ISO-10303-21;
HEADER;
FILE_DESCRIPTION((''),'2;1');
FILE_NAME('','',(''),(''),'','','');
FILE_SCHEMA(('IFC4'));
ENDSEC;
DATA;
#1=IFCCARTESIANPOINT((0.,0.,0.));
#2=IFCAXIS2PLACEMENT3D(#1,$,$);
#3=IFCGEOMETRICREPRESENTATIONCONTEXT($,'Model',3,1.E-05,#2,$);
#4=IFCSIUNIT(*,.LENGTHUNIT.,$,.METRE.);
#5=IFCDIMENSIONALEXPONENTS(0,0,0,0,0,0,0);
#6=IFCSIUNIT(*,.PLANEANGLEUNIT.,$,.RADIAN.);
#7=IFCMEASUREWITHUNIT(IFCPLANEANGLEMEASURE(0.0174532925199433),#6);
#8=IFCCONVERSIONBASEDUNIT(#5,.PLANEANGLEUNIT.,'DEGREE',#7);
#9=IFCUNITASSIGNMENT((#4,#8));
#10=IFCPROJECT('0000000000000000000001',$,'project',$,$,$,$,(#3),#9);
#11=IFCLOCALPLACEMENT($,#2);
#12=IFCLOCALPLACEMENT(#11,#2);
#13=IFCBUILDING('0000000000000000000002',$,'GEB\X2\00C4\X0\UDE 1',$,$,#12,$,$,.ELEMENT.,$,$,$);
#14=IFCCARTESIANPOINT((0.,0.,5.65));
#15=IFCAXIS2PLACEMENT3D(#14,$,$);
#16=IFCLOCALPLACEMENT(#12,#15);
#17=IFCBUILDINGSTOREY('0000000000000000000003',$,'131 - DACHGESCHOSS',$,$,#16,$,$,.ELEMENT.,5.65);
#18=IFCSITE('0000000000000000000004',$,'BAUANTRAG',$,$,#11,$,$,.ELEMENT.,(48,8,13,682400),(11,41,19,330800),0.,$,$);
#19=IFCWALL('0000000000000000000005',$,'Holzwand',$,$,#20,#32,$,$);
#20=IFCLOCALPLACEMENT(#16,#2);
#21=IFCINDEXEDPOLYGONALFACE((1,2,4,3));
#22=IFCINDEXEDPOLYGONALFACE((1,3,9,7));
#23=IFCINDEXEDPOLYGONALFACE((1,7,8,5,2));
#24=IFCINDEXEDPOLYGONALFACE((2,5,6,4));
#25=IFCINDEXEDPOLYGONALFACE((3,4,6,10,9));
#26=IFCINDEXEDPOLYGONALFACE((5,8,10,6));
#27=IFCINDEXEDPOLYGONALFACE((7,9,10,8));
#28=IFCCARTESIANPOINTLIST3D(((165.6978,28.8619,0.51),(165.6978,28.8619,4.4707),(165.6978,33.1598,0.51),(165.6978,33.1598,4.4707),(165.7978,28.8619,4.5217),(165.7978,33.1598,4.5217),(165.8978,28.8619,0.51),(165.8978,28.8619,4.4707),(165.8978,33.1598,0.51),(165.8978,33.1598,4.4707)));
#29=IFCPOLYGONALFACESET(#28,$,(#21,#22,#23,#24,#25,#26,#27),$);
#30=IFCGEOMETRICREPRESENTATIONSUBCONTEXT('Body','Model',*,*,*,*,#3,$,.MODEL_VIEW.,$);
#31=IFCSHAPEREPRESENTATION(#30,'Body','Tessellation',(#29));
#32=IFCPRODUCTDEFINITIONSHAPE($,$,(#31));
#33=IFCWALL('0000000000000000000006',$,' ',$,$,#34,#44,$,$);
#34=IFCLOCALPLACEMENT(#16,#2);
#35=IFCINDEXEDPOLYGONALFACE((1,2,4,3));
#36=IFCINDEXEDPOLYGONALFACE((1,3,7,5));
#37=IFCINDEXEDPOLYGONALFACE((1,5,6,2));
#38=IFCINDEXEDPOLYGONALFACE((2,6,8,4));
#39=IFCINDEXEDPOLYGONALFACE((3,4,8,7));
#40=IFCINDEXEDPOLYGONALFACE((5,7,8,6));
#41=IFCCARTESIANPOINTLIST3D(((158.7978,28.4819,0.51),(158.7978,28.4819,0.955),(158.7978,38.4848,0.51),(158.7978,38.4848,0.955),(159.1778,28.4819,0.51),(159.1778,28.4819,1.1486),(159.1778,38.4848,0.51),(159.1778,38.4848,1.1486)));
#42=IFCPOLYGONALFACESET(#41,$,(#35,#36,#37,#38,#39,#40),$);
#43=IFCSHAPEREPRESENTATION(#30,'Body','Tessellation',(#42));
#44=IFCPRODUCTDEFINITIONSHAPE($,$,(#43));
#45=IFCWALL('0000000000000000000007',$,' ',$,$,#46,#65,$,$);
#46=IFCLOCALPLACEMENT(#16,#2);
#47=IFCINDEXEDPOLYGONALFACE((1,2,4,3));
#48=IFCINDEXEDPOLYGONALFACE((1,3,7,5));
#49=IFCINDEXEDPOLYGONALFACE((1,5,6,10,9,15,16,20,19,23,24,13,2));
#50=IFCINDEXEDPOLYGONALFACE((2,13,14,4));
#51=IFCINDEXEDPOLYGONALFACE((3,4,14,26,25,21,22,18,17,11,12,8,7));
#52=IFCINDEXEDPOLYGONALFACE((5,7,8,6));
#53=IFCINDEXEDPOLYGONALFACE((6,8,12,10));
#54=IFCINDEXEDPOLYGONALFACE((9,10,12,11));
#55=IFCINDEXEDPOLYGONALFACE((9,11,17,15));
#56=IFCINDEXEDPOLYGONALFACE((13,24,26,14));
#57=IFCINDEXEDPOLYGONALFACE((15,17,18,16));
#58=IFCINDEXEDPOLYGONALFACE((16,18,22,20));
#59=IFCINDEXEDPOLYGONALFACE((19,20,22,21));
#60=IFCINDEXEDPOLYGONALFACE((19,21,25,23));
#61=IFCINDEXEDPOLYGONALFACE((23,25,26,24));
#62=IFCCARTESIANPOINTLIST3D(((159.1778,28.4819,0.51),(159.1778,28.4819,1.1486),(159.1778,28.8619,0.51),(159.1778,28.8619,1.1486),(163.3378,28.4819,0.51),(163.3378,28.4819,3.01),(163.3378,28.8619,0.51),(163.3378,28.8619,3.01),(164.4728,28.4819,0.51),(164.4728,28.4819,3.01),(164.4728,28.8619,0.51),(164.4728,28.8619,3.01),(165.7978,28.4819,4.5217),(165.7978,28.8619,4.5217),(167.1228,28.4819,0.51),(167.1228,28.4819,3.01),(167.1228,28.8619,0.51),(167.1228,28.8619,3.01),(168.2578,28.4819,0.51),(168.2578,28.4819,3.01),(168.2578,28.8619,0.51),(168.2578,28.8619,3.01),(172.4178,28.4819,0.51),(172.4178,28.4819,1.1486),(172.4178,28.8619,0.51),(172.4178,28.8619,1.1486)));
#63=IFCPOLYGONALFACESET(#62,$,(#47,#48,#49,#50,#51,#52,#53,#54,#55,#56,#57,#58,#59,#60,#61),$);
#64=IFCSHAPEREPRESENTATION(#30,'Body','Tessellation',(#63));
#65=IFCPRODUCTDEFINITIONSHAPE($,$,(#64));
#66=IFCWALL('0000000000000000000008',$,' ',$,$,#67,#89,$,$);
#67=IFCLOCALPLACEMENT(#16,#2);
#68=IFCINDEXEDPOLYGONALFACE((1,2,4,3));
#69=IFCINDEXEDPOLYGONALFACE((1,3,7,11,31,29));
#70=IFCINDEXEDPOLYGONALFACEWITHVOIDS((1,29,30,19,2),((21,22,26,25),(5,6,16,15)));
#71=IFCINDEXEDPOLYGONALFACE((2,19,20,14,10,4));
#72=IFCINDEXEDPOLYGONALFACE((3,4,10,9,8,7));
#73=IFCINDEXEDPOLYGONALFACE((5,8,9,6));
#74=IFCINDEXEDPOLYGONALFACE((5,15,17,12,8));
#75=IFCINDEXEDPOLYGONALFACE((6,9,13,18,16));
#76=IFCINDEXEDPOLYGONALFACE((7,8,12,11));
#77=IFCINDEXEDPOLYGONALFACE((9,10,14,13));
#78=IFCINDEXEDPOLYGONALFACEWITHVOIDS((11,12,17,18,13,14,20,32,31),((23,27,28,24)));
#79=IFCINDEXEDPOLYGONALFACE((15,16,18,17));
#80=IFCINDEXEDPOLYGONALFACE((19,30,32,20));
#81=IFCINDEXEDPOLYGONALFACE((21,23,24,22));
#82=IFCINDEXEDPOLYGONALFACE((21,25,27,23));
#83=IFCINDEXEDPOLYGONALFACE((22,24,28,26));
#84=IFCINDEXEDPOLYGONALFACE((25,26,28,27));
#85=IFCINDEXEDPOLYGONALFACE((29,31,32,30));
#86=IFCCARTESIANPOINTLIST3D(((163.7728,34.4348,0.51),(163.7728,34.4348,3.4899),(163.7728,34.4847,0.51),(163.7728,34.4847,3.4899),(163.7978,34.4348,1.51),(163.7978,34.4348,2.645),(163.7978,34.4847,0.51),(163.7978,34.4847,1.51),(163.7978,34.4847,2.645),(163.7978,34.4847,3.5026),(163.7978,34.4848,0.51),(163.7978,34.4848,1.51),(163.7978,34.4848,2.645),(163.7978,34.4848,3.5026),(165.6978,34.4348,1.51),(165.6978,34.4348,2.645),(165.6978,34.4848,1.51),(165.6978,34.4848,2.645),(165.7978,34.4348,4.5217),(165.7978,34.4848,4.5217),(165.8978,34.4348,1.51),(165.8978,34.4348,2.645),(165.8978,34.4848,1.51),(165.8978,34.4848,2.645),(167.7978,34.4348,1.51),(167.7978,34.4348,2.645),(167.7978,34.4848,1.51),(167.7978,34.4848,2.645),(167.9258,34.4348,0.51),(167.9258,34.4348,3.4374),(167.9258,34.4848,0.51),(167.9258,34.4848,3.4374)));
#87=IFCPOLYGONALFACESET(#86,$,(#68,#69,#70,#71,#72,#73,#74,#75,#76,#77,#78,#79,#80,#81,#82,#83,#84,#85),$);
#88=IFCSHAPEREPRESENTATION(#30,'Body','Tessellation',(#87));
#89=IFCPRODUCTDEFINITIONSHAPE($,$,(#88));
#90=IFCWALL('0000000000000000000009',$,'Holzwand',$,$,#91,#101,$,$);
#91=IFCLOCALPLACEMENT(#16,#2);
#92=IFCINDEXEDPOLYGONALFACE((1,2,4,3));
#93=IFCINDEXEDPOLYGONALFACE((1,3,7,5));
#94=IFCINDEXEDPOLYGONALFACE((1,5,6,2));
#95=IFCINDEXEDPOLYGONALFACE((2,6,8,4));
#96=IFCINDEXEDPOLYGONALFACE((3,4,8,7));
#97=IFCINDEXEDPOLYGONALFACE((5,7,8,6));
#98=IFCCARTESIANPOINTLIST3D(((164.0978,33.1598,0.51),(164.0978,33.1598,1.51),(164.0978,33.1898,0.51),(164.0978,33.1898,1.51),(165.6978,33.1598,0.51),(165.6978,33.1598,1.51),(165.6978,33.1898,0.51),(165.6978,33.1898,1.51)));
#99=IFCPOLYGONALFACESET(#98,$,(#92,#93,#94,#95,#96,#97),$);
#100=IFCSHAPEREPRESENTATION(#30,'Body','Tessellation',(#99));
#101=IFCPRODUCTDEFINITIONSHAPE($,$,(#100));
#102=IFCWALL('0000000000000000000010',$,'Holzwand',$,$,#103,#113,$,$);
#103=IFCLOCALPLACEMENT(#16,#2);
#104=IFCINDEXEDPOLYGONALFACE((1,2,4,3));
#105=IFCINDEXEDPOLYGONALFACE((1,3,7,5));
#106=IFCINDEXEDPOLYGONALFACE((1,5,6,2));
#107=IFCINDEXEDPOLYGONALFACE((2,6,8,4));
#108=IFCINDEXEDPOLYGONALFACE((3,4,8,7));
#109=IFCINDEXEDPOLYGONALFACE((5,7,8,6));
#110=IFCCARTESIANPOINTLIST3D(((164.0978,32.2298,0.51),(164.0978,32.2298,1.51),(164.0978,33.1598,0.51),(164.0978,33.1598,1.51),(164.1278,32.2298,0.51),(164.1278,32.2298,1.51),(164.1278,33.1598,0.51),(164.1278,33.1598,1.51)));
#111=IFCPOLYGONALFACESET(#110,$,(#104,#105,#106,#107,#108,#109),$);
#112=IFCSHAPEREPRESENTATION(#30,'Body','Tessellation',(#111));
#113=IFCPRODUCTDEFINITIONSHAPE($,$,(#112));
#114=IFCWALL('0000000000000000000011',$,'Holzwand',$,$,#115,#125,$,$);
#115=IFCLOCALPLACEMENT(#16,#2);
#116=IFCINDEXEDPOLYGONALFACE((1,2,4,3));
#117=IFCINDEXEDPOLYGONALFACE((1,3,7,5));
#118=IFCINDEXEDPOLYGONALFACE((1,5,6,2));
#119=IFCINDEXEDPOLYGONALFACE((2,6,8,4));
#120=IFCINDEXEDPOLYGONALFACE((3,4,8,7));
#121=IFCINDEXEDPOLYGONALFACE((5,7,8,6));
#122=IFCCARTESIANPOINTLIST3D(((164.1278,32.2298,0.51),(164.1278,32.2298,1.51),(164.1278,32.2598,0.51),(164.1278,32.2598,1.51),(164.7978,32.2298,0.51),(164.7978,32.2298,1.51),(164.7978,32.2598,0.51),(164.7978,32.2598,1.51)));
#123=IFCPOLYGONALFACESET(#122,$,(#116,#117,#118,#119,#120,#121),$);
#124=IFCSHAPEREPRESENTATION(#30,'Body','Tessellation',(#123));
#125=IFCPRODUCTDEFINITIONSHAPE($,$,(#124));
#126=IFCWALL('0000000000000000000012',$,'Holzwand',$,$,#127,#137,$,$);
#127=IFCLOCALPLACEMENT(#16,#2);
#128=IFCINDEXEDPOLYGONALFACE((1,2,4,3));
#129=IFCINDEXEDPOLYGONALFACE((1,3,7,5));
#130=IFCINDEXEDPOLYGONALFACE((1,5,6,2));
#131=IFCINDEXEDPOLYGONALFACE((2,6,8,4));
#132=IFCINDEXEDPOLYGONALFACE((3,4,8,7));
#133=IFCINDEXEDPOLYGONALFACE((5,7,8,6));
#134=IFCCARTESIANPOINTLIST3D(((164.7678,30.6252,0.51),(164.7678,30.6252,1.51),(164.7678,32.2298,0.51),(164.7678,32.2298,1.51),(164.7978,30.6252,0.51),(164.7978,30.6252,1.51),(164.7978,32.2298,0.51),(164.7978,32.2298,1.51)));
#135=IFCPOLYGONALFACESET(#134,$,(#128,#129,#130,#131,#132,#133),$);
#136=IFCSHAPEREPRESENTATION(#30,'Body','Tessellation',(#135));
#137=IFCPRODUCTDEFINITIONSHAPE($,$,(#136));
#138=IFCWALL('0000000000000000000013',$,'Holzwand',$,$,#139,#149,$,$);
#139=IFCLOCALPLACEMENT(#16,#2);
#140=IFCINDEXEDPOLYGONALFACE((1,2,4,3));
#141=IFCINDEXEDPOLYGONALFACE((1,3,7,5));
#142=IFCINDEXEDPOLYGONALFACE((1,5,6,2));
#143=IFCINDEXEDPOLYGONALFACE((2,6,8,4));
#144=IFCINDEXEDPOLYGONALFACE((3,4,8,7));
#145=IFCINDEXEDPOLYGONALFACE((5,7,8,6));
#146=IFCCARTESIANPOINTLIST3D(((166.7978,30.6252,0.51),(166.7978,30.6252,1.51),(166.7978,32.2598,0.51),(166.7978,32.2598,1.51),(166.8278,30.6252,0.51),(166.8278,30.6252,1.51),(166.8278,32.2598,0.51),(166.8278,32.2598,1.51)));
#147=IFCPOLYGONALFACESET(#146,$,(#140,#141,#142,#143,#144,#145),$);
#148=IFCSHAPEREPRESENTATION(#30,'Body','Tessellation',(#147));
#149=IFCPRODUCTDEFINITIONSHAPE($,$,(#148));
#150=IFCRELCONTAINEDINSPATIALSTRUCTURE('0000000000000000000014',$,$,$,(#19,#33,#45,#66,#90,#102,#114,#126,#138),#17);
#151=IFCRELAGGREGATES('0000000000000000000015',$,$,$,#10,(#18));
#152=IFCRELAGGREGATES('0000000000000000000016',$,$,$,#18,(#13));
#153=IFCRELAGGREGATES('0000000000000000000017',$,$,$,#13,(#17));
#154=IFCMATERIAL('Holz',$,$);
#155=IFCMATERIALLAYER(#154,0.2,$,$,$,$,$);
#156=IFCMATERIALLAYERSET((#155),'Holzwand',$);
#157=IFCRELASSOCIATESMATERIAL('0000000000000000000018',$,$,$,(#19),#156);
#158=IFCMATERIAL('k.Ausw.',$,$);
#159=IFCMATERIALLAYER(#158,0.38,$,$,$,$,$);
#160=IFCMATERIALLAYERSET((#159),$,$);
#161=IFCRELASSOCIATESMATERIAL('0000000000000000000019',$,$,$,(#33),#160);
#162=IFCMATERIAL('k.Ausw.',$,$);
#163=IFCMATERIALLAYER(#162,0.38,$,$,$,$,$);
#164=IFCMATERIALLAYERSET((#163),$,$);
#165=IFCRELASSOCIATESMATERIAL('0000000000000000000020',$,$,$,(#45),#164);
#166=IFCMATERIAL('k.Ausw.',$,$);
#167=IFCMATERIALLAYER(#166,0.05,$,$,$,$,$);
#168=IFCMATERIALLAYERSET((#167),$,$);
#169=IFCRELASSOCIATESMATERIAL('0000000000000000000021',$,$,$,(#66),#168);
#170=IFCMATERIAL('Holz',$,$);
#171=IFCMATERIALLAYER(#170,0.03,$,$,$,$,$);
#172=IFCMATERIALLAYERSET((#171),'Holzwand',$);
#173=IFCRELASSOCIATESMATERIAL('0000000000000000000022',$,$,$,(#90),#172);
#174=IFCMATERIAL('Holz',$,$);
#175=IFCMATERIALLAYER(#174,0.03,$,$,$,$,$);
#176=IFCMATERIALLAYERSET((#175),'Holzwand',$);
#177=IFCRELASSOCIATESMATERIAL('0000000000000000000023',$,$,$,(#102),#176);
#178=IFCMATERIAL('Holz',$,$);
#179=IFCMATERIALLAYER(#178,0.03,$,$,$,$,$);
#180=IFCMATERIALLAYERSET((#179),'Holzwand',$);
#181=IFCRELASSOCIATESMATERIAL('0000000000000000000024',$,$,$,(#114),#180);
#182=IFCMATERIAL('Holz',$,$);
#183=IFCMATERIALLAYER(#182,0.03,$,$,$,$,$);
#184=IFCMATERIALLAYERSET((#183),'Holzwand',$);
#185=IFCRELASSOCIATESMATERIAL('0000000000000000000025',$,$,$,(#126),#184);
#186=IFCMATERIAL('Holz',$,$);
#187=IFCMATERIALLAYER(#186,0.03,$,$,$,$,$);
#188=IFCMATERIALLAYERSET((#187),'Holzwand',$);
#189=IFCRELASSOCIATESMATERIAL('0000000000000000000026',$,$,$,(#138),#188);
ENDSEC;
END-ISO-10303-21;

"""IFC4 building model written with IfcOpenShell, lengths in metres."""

from ifc_helpers import new_model, entity, si_unit, converted_unit, frame, frame_2d, origin, origin_with_axes, place, context, subcontext, project, spatial, polyline, rectangle, outline, extrude, clip, halfspace, bounded_halfspace, material, layer, layer_set, layer_usage, element, save


model = new_model("IFC4")

# Units and contexts
model_context = context("Model", 3, precision=1e-05, world=origin())
body_context = subcontext(model_context, "Body", "Model", "MODEL_VIEW")
ifc_project = project(units=[si_unit("LENGTHUNIT", "METRE"), converted_unit("PLANEANGLEUNIT", "DEGREE", entity("IfcPlaneAngleMeasure", 0.0174532925199433), si_unit("PLANEANGLEUNIT", "RADIAN"), dimensions=[0, 0, 0, 0, 0, 0, 0])], contexts=[model_context])

# Site, building, storey
site_placement = place(None, origin())
site = spatial("IfcSite", under=ifc_project, at=site_placement, Name="BAUANTRAG", CompositionType="ELEMENT", RefLatitude=(48, 8, 13, 682400), RefLongitude=(11, 41, 19, 330800), RefElevation=0.0)
building_placement = place(site_placement, origin())
building = spatial("IfcBuilding", under=site, at=building_placement, Name="GEBÄUDE 1", CompositionType="ELEMENT")
storey_placement = place(building_placement, frame((0.0, 0.0, 5.65)))
storey = spatial("IfcBuildingStorey", under=building, at=storey_placement, Name="131 - DACHGESCHOSS", CompositionType="ELEMENT", Elevation=5.65)

# Walls
ifc_material_1 = material(Name="Holz")
ifc_layer_1 = layer(ifc_material_1, 0.2)
ifc_layer_set_1 = layer_set([ifc_layer_1], Name="Holzwand")
ifc_layer_usage_1 = layer_usage(ifc_layer_set_1, "AXIS2", "POSITIVE", 0.0)
wall_1_placement = place(storey_placement, frame((165.6978, 33.1598, 0.51), z_axis=(0.0, 0.0, 1.0), x_axis=(0.0, -1.0, 0.0)))
element("IfcWall", 1, at=wall_1_placement, inside=storey, material=ifc_layer_usage_1, Name="Holzwand", context=body_context, shape_type="Clipping", body=[
    clip(clip(extrude(rectangle(XDim=4.2979, YDim=0.2, at=frame_2d((2.1489, 0.1), x_axis=(1.0, 0.0))), origin_with_axes(), (0.0, 0.0, 1.0), 4.0117), bounded_halfspace(frame((2.1489, 0.05, 3.9862), z_axis=(0.0, 0.45399, -0.891007), x_axis=(0.0, 0.891007, 0.45399)), True, origin_with_axes(), polyline([(4.2979, 0.0), (4.2979, 0.1), (0.0, 0.1), (0.0, 0.0), (4.2979, 0.0)]))), bounded_halfspace(frame((2.1489, 0.15, 3.9862), z_axis=(0.0, -0.45399, -0.891007), x_axis=(0.0, -0.891007, 0.45399)), True, origin_with_axes(), polyline([(0.0, 0.2), (0.0, 0.1), (4.2979, 0.1), (4.2979, 0.2), (0.0, 0.2)]))),
])
ifc_material_2 = material(Name="k.Ausw.")
ifc_layer_2 = layer(ifc_material_2, 0.38)
ifc_layer_set_2 = layer_set([ifc_layer_2])
ifc_layer_usage_2 = layer_usage(ifc_layer_set_2, "AXIS2", "POSITIVE", 0.0)
wall_2_placement = place(storey_placement, frame((158.7978, 38.4848, 0.51), z_axis=(0.0, 0.0, 1.0), x_axis=(0.0, -1.0, 0.0)))
element("IfcWall", 2, at=wall_2_placement, inside=storey, material=ifc_layer_usage_2, Name=" ", context=body_context, shape_type="Clipping", body=[
    clip(extrude(rectangle(XDim=10.0029, YDim=0.38, at=frame_2d((5.0014, 0.19), x_axis=(1.0, 0.0))), origin_with_axes(), (0.0, 0.0, 1.0), 0.6386), halfspace(frame((5.0014, 0.19, 0.5418), z_axis=(0.0, 0.45399, -0.891007), x_axis=(0.0, -0.891007, -0.45399)), True)),
])

# Walls, openings
ifc_material_3 = material(Name="k.Ausw.")
ifc_layer_3 = layer(ifc_material_3, 0.38)
ifc_layer_set_3 = layer_set([ifc_layer_3])
ifc_layer_usage_3 = layer_usage(ifc_layer_set_3, "AXIS2", "POSITIVE", 0.0)
wall_3_placement = place(storey_placement, frame((159.1778, 28.4819, 0.51), z_axis=(0.0, 0.0, 1.0), x_axis=(1.0, 0.0, 0.0)))
wall_3 = element("IfcWall", 3, at=wall_3_placement, inside=storey, material=ifc_layer_usage_3, Name=" ", context=body_context, shape_type="Clipping", body=[
    clip(clip(extrude(rectangle(XDim=13.24, YDim=0.38, at=frame_2d((6.62, 0.19), x_axis=(1.0, 0.0))), origin_with_axes(), (0.0, 0.0, 1.0), 4.0117), bounded_halfspace(frame((3.31, 0.19, 2.3251), z_axis=(0.45399, 0.0, -0.891007), x_axis=(0.0, -1.0, 0.0)), True, origin_with_axes(), polyline([(0.0, 0.38), (0.0, 0.0), (6.62, 0.0), (6.62, 0.38), (0.0, 0.38)]))), bounded_halfspace(frame((9.93, 0.19, 2.3251), z_axis=(-0.45399, 0.0, -0.891007), x_axis=(0.891007, 0.0, -0.45399)), True, origin_with_axes(), polyline([(6.62, 0.0), (13.24, 0.0), (13.24, 0.38), (6.62, 0.38), (6.62, 0.0)]))),
])
opening_1_placement = place(wall_3_placement, frame((5.295, 0.38, 0.0), z_axis=(0.0, -1.0, 0.0), x_axis=(0.0, 0.0, 1.0)))
element("IfcOpeningElement", 4, at=opening_1_placement, cuts=wall_3, ObjectType="Opening", context=body_context, shape_type="SweptSolid", body=[
    extrude(outline(polyline([(0.0, 1.135), (2.5, 1.135), (2.5, 0.0), (0.0, 0.0), (0.0, 1.135)])), origin_with_axes(), (0.0, 0.0, 1.0), 0.38),
])
opening_2_placement = place(wall_3_placement, frame((9.08, 0.38, 0.0), z_axis=(0.0, -1.0, 0.0), x_axis=(0.0, 0.0, 1.0)))
element("IfcOpeningElement", 5, at=opening_2_placement, cuts=wall_3, ObjectType="Opening", context=body_context, shape_type="SweptSolid", body=[
    extrude(outline(polyline([(0.0, 1.135), (2.5, 1.135), (2.5, 0.0), (0.0, 0.0), (0.0, 1.135)])), origin_with_axes(), (0.0, 0.0, 1.0), 0.38),
])
ifc_material_4 = material(Name="k.Ausw.")
ifc_layer_4 = layer(ifc_material_4, 0.05)
ifc_layer_set_4 = layer_set([ifc_layer_4])
ifc_layer_usage_4 = layer_usage(ifc_layer_set_4, "AXIS2", "POSITIVE", 0.0)
wall_4_placement = place(storey_placement, frame((163.7728, 34.4348, 0.51), z_axis=(0.0, 0.0, 1.0), x_axis=(1.0, 0.0, 0.0)))
wall_4 = element("IfcWall", 6, at=wall_4_placement, inside=storey, material=ifc_layer_usage_4, Name=" ", context=body_context, shape_type="Clipping", body=[
    clip(clip(extrude(outline(polyline([(0.0, 0.0), (4.153, 0.0), (4.153, 0.05), (0.025, 0.05), (0.025, 0.0499), (0.0, 0.0499), (0.0, 0.0)])), origin_with_axes(), (0.0, 0.0, 1.0), 4.0117), bounded_halfspace(frame((0.6833, 0.0333, 3.3281), z_axis=(0.45399, 0.0, -0.891007), x_axis=(0.891007, 0.0, 0.45399)), True, origin_with_axes(), polyline([(0.0, 0.0), (2.025, 0.0), (2.025, 0.05), (0.025, 0.05), (0.025, 0.0499), (0.0, 0.0499), (0.0, 0.0)]))), bounded_halfspace(frame((3.089, 0.025, 3.4695), z_axis=(-0.45399, 0.0, -0.891007), x_axis=(-0.891007, 0.0, 0.45399)), True, origin_with_axes(), polyline([(4.153, 0.05), (2.025, 0.05), (2.025, 0.0), (4.153, 0.0), (4.153, 0.05)]))),
])
opening_3_placement = place(wall_4_placement, frame((0.025, 0.0, 1.0), z_axis=(0.0, 1.0, 0.0), x_axis=(0.0, 0.0, 1.0)))
element("IfcOpeningElement", 7, at=opening_3_placement, cuts=wall_4, ObjectType="Opening", context=body_context, shape_type="SweptSolid", body=[
    extrude(outline(polyline([(0.0, 1.9), (1.135, 1.9), (1.135, 0.0), (0.0, 0.0), (0.0, 1.9)])), origin_with_axes(), (0.0, 0.0, 1.0), 0.05),
])
opening_4_placement = place(wall_4_placement, frame((2.125, 0.0, 1.0), z_axis=(0.0, 1.0, 0.0), x_axis=(0.0, 0.0, 1.0)))
element("IfcOpeningElement", 8, at=opening_4_placement, cuts=wall_4, ObjectType="Opening", context=body_context, shape_type="SweptSolid", body=[
    extrude(outline(polyline([(0.0, 1.9), (1.135, 1.9), (1.135, 0.0), (0.0, 0.0), (0.0, 1.9)])), origin_with_axes(), (0.0, 0.0, 1.0), 0.05),
])

# Walls
ifc_material_5 = material(Name="Holz")
ifc_layer_5 = layer(ifc_material_5, 0.03)
ifc_layer_set_5 = layer_set([ifc_layer_5], Name="Holzwand")
ifc_layer_usage_5 = layer_usage(ifc_layer_set_5, "AXIS2", "POSITIVE", 0.0)
wall_5_placement = place(storey_placement, frame((164.0978, 33.1598, 0.51)))
element("IfcWall", 9, at=wall_5_placement, inside=storey, material=ifc_layer_usage_5, Name="Holzwand", context=body_context, shape_type="SweptSolid", body=[
    extrude(rectangle(XDim=1.6, YDim=0.03, at=frame_2d((0.8, 0.015), x_axis=(1.0, 0.0))), origin_with_axes(), (0.0, 0.0, 1.0), 1.0),
])
ifc_material_6 = material(Name="Holz")
ifc_layer_6 = layer(ifc_material_6, 0.03)
ifc_layer_set_6 = layer_set([ifc_layer_6], Name="Holzwand")
ifc_layer_usage_6 = layer_usage(ifc_layer_set_6, "AXIS2", "POSITIVE", 0.0)
wall_6_placement = place(storey_placement, frame((164.1278, 32.2298, 0.51), z_axis=(0.0, 0.0, 1.0), x_axis=(0.0, 1.0, 0.0)))
element("IfcWall", 10, at=wall_6_placement, inside=storey, material=ifc_layer_usage_6, Name="Holzwand", context=body_context, shape_type="SweptSolid", body=[
    extrude(rectangle(XDim=0.93, YDim=0.03, at=frame_2d((0.465, 0.015), x_axis=(1.0, 0.0))), origin_with_axes(), (0.0, 0.0, 1.0), 1.0),
])
ifc_material_7 = material(Name="Holz")
ifc_layer_7 = layer(ifc_material_7, 0.03)
ifc_layer_set_7 = layer_set([ifc_layer_7], Name="Holzwand")
ifc_layer_usage_7 = layer_usage(ifc_layer_set_7, "AXIS2", "POSITIVE", 0.0)
wall_7_placement = place(storey_placement, frame((164.7978, 32.2598, 0.51), z_axis=(0.0, 0.0, 1.0), x_axis=(-1.0, 0.0, 0.0)))
element("IfcWall", 11, at=wall_7_placement, inside=storey, material=ifc_layer_usage_7, Name="Holzwand", context=body_context, shape_type="SweptSolid", body=[
    extrude(rectangle(XDim=0.67, YDim=0.03, at=frame_2d((0.335, 0.015), x_axis=(1.0, 0.0))), origin_with_axes(), (0.0, 0.0, 1.0), 1.0),
])
ifc_material_8 = material(Name="Holz")
ifc_layer_8 = layer(ifc_material_8, 0.03)
ifc_layer_set_8 = layer_set([ifc_layer_8], Name="Holzwand")
ifc_layer_usage_8 = layer_usage(ifc_layer_set_8, "AXIS2", "POSITIVE", 0.0)
wall_8_placement = place(storey_placement, frame((164.7978, 30.6252, 0.51), z_axis=(0.0, 0.0, 1.0), x_axis=(0.0, 1.0, 0.0)))
element("IfcWall", 12, at=wall_8_placement, inside=storey, material=ifc_layer_usage_8, Name="Holzwand", context=body_context, shape_type="SweptSolid", body=[
    extrude(rectangle(XDim=1.6046, YDim=0.03, at=frame_2d((0.8023, 0.015), x_axis=(1.0, 0.0))), origin_with_axes(), (0.0, 0.0, 1.0), 1.0),
])
ifc_material_9 = material(Name="Holz")
ifc_layer_9 = layer(ifc_material_9, 0.03)
ifc_layer_set_9 = layer_set([ifc_layer_9], Name="Holzwand")
ifc_layer_usage_9 = layer_usage(ifc_layer_set_9, "AXIS2", "POSITIVE", 0.0)
wall_9_placement = place(storey_placement, frame((166.7978, 32.2598, 0.51), z_axis=(0.0, 0.0, 1.0), x_axis=(0.0, -1.0, 0.0)))
element("IfcWall", 13, at=wall_9_placement, inside=storey, material=ifc_layer_usage_9, Name="Holzwand", context=body_context, shape_type="SweptSolid", body=[
    extrude(rectangle(XDim=1.6346, YDim=0.03, at=frame_2d((0.8173, 0.015), x_axis=(1.0, 0.0))), origin_with_axes(), (0.0, 0.0, 1.0), 1.0),
])

save(model, "model.ifc")
